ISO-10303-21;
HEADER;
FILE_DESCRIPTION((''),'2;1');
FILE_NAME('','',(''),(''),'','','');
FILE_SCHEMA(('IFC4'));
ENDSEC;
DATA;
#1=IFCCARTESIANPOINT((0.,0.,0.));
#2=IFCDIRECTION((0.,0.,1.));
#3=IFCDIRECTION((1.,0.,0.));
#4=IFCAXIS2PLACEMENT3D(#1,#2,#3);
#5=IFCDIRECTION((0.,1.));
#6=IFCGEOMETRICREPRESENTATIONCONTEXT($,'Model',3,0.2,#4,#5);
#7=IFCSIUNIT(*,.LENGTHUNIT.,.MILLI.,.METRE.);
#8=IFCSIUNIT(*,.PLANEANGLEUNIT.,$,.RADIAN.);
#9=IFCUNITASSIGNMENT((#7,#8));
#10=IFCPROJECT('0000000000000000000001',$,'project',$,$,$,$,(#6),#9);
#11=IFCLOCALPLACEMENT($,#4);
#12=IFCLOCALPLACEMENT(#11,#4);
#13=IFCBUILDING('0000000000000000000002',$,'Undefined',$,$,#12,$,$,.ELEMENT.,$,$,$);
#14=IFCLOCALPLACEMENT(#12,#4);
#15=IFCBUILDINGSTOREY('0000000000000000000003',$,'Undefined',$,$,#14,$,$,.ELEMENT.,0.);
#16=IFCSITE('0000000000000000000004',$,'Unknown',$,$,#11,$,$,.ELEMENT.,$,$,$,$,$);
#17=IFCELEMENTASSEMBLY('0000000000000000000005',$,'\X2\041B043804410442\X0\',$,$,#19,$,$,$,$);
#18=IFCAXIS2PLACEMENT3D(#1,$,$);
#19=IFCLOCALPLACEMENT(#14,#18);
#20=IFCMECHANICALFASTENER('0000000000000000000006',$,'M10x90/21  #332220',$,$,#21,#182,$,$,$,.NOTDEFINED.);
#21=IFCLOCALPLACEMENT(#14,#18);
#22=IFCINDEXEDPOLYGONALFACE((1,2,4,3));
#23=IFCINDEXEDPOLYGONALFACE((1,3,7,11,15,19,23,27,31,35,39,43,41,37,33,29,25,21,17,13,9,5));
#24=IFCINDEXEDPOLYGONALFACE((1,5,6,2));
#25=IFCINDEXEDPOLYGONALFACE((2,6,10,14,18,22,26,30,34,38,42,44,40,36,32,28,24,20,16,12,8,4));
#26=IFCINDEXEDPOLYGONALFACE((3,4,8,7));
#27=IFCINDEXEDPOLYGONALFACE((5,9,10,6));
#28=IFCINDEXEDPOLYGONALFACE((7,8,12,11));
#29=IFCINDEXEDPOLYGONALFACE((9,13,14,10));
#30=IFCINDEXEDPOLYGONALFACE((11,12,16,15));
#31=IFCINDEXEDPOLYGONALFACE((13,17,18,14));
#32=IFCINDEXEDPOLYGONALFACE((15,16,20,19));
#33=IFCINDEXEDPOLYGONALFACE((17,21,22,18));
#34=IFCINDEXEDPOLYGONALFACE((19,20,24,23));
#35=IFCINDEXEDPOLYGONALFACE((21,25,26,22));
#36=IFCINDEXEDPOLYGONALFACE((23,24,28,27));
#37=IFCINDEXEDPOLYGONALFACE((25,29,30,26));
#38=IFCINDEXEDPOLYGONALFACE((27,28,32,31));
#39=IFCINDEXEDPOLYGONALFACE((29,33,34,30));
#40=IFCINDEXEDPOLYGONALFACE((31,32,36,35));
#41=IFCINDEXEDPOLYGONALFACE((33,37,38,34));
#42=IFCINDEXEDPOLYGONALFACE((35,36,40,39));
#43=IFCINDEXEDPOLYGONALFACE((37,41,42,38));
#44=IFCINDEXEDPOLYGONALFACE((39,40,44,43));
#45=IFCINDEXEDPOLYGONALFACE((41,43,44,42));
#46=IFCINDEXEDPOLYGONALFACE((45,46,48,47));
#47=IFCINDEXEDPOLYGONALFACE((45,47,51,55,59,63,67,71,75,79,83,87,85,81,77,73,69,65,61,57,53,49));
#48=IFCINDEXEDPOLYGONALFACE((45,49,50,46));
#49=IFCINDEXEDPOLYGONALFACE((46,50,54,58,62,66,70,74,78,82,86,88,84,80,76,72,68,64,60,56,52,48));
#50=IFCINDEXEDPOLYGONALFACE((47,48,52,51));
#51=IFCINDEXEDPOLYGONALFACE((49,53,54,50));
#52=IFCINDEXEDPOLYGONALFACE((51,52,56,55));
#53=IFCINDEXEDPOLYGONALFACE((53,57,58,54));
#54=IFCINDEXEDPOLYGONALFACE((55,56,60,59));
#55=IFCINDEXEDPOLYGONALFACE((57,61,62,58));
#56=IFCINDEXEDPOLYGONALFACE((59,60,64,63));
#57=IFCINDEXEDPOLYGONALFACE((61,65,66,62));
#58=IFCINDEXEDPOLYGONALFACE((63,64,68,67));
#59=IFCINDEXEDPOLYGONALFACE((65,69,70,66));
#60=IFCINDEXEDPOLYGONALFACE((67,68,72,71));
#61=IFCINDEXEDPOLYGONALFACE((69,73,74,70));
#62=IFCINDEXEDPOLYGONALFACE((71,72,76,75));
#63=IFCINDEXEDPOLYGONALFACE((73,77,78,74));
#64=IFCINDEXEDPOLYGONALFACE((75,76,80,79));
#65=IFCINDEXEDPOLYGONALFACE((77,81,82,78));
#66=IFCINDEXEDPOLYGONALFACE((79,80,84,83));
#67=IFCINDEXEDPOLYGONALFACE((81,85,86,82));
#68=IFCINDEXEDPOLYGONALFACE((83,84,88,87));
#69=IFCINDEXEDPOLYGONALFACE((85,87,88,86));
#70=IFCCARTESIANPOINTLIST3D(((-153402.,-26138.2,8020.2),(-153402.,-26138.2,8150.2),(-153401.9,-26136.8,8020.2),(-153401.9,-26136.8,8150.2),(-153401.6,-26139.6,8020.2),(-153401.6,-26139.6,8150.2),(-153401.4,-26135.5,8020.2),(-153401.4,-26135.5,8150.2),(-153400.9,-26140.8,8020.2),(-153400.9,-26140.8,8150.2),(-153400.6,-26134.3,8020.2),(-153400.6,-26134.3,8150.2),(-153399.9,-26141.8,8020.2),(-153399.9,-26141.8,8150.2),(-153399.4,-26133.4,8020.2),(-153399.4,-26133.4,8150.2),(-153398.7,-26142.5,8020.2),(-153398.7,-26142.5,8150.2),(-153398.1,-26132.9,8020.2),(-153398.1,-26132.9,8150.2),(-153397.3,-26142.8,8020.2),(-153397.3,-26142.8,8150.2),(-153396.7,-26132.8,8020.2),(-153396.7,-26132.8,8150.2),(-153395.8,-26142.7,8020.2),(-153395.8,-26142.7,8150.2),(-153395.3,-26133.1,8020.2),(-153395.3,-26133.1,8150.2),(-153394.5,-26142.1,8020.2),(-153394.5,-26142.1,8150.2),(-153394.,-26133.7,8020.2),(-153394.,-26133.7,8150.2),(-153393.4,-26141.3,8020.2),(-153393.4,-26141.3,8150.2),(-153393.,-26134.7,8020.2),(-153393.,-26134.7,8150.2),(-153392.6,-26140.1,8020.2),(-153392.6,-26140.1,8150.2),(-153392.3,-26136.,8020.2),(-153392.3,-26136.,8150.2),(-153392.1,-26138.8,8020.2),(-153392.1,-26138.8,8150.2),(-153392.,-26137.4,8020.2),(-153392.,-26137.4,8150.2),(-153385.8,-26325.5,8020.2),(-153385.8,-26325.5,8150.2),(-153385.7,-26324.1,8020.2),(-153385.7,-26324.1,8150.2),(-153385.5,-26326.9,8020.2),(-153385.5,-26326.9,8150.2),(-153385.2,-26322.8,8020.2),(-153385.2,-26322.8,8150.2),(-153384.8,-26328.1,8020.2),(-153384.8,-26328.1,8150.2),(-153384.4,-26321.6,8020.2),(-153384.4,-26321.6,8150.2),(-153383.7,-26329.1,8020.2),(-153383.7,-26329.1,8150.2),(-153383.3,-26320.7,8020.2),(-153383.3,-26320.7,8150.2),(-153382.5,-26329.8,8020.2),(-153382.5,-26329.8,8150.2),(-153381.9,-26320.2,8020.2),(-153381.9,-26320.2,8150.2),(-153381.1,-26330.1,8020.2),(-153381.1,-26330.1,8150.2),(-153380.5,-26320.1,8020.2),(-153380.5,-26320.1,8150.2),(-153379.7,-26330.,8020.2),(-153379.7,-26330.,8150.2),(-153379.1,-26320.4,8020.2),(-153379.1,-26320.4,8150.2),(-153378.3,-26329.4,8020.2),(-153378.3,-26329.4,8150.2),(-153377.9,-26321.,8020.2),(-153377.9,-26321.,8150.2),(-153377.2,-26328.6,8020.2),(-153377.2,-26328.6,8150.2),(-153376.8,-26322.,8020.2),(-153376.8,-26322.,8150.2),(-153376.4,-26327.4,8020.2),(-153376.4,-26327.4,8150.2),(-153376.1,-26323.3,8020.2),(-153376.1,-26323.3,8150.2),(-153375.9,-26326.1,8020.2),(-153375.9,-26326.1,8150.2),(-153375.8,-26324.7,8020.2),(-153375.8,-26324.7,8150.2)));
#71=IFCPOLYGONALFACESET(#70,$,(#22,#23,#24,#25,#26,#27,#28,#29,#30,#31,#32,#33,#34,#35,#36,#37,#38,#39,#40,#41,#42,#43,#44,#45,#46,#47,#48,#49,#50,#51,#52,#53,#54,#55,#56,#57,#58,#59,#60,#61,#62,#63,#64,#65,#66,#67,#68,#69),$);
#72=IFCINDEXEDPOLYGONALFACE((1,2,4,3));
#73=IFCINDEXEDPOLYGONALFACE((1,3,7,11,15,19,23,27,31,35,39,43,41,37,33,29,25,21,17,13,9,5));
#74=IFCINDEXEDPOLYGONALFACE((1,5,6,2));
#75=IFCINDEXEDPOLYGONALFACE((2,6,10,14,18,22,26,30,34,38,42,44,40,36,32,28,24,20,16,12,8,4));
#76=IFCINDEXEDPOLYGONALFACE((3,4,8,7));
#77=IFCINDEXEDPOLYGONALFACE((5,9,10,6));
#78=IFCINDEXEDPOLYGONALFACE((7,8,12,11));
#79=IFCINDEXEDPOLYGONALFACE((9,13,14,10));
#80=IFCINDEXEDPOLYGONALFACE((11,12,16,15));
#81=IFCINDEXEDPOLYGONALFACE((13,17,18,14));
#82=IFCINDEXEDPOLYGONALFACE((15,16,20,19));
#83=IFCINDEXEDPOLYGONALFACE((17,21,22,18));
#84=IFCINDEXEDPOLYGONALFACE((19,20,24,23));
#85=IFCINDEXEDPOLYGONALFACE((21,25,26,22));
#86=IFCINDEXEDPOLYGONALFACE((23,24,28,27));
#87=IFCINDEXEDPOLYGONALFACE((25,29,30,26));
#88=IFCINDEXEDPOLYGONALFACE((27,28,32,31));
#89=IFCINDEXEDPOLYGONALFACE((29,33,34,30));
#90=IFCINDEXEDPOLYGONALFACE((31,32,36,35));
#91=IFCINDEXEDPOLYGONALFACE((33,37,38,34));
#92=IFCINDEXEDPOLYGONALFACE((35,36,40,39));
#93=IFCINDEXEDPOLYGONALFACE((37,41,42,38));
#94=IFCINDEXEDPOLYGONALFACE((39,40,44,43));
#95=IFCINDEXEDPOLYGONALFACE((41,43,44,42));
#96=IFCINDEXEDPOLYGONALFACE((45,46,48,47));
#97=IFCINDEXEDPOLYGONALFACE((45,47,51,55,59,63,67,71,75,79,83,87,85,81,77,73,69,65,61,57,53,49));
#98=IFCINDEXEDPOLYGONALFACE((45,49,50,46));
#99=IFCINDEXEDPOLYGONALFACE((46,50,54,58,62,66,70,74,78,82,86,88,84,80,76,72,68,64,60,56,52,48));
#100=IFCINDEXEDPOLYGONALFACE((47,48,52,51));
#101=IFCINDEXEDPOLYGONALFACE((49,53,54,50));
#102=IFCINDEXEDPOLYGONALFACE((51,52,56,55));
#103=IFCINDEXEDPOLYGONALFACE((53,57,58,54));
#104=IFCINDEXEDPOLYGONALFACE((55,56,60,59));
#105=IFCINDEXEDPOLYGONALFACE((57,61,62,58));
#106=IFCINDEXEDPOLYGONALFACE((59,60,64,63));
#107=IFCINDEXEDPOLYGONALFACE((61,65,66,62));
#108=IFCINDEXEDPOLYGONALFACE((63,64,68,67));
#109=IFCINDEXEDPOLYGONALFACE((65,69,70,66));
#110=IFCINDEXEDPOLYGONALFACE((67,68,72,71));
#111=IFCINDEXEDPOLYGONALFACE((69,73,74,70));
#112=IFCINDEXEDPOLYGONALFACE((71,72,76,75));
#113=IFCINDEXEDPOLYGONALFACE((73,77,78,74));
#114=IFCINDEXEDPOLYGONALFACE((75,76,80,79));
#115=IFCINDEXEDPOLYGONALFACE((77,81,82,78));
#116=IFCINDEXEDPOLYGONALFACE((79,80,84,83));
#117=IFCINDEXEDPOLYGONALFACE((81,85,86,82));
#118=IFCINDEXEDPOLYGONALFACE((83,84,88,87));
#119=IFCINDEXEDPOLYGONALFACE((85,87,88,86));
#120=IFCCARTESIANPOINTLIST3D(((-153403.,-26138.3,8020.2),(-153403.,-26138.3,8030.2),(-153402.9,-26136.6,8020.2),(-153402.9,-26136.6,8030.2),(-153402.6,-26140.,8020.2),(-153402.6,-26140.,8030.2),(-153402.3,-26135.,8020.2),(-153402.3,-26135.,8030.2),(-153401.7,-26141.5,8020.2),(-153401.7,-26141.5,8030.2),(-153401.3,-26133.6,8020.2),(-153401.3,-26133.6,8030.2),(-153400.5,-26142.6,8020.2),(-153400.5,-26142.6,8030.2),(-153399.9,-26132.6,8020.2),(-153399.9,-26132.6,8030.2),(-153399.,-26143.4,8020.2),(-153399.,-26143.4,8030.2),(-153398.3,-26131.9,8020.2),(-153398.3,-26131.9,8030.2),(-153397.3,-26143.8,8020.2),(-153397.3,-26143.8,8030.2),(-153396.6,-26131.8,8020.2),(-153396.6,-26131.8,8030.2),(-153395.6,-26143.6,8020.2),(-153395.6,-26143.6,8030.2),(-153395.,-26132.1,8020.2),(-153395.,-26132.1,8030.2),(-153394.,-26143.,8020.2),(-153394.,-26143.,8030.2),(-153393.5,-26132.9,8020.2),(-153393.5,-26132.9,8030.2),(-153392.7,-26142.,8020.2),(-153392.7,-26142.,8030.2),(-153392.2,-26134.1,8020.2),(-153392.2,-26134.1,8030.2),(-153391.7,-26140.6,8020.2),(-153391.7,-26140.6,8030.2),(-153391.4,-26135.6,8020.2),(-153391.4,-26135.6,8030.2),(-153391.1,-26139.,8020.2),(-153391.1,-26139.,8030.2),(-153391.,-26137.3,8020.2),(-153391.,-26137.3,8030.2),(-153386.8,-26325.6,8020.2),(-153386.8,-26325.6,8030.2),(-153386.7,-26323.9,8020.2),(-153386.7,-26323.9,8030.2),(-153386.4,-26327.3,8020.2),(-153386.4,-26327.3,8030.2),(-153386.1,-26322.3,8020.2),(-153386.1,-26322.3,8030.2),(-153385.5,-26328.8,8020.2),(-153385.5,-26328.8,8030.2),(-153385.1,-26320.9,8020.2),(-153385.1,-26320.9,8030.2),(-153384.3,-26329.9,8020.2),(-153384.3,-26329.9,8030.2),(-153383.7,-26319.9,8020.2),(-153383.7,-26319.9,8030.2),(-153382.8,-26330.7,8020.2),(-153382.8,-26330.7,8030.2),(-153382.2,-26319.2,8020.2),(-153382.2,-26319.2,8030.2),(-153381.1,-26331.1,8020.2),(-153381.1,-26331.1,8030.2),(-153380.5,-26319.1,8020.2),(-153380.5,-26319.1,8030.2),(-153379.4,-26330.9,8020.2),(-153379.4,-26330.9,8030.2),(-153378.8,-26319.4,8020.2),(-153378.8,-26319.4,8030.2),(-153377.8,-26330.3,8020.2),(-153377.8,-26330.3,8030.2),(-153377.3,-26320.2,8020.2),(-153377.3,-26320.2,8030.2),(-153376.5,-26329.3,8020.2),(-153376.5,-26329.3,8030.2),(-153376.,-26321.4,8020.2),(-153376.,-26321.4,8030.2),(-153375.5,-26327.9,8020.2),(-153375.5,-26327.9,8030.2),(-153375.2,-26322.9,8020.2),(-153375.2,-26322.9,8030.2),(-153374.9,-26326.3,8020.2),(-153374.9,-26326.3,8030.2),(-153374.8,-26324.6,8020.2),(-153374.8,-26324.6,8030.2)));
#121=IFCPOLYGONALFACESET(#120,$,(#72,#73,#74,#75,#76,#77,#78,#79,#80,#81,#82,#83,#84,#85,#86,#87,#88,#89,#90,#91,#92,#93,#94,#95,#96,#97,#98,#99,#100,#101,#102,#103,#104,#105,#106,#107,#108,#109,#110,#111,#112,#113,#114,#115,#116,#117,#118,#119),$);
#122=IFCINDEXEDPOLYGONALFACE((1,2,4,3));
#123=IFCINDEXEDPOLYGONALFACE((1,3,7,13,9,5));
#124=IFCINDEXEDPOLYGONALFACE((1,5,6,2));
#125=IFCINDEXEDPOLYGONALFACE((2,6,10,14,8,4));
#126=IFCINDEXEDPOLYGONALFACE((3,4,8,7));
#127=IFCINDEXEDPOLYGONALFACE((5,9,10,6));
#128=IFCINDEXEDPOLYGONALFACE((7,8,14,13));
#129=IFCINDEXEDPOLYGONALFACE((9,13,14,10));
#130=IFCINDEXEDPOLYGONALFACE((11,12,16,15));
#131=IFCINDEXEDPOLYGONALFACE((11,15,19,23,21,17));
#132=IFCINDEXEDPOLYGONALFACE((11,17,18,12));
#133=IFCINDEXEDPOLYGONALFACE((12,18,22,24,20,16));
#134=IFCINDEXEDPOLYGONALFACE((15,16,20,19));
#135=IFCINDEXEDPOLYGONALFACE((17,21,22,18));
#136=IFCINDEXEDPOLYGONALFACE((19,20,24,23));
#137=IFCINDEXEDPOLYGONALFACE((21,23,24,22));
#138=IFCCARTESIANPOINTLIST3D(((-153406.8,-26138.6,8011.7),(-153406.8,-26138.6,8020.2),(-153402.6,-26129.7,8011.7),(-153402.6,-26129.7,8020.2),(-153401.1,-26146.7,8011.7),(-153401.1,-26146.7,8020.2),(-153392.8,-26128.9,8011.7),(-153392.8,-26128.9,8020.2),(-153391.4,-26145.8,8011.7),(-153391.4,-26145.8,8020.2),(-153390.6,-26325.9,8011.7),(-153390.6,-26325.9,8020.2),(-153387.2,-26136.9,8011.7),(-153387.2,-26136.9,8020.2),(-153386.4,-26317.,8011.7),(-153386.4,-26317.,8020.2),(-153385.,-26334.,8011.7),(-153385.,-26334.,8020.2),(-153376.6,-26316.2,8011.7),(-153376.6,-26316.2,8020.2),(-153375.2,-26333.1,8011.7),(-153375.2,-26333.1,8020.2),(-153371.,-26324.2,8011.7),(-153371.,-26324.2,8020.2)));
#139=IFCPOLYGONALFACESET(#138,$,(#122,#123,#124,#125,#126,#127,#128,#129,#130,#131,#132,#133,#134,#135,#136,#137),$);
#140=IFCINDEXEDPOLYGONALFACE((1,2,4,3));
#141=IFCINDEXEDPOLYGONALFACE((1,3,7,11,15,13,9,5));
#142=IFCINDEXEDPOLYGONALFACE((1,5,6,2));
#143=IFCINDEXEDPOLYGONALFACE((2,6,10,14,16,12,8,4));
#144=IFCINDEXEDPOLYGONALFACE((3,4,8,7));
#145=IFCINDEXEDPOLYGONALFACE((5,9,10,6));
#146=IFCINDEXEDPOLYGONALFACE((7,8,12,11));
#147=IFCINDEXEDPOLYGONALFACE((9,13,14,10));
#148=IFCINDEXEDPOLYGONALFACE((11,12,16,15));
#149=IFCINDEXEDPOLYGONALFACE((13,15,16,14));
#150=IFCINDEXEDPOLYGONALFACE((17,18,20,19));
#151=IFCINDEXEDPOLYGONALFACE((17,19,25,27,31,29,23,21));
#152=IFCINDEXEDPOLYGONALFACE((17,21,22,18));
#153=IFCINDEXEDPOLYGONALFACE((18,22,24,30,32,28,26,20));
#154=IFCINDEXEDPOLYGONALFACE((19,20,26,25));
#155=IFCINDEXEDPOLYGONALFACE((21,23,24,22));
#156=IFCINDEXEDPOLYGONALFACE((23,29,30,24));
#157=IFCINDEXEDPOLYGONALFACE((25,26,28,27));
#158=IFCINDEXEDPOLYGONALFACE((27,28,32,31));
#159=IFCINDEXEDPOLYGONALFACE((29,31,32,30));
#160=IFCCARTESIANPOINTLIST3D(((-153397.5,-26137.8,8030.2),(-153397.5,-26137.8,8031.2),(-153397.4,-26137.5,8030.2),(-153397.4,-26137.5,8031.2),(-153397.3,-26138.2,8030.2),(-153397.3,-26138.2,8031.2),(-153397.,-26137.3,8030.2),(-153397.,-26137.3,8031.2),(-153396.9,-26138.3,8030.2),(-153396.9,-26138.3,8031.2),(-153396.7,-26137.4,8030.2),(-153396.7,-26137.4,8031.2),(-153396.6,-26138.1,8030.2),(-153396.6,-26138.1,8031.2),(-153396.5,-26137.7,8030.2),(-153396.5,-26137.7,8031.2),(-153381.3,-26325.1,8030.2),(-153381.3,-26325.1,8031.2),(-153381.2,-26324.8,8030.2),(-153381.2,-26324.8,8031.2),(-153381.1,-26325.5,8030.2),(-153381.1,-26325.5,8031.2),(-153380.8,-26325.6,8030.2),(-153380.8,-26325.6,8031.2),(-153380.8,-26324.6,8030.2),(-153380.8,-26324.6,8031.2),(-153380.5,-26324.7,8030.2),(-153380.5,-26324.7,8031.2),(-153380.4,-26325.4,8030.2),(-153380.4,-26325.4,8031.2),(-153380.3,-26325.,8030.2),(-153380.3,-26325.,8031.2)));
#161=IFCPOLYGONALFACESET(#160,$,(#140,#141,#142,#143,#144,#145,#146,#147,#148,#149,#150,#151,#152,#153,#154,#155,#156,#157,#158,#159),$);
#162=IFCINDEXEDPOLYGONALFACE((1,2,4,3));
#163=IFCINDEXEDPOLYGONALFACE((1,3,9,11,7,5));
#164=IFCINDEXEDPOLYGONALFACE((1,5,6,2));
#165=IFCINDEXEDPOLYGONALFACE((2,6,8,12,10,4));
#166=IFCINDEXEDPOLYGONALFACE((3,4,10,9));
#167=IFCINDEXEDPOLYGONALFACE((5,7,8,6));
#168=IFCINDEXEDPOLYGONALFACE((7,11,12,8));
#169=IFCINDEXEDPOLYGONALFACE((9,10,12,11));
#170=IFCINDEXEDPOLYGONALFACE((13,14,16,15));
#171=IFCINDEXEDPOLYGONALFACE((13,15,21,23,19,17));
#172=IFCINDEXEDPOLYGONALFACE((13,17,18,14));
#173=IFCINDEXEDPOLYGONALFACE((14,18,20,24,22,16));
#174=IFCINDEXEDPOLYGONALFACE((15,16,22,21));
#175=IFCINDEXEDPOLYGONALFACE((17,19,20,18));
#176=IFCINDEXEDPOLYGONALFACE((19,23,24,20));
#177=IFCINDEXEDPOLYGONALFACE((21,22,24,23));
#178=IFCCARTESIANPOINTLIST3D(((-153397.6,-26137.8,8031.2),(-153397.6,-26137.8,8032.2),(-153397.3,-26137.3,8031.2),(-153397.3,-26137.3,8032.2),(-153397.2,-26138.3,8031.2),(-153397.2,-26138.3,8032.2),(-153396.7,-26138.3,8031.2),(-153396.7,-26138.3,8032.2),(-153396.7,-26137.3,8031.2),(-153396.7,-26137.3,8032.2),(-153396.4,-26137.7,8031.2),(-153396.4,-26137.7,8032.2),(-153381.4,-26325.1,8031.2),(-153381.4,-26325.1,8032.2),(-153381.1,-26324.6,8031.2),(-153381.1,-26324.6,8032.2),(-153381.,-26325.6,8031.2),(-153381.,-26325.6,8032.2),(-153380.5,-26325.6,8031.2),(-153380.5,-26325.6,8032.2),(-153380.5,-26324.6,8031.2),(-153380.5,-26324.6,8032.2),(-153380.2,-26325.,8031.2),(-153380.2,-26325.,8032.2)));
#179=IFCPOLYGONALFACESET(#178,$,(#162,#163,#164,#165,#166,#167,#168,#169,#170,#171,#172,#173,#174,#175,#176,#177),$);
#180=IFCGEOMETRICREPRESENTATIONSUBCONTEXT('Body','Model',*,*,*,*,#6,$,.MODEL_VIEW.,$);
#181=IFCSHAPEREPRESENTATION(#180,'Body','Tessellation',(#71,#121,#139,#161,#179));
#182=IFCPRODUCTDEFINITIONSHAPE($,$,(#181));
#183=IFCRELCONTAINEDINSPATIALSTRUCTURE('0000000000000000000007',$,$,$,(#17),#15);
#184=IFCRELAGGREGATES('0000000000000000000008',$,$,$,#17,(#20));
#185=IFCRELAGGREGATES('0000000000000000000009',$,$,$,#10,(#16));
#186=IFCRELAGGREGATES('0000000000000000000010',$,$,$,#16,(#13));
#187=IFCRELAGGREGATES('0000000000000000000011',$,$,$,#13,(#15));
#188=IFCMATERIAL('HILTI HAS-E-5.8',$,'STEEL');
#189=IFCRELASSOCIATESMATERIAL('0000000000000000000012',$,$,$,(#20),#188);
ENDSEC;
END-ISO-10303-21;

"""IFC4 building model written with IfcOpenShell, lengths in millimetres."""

from ifc_helpers import new_model, si_unit, direction, frame, origin_with_axes, place, context, subcontext, project, spatial, line, arc, indexed_curve, outline, extrude, source, transform, mapped, material, element, aggregate, save


model = new_model("IFC4")

# Units and contexts
model_context = context("Model", 3, precision=0.2, world=origin_with_axes(), true_north=direction((0.0, 1.0)))
body_context = subcontext(model_context, "Body", "Model", "MODEL_VIEW")
ifc_project = project(units=[si_unit("LENGTHUNIT", "METRE", prefix="MILLI"), si_unit("PLANEANGLEUNIT", "RADIAN")], contexts=[model_context])

# Site, building, storey
site_placement = place(None, origin_with_axes())
site = spatial("IfcSite", under=ifc_project, at=site_placement, Name="Unknown", CompositionType="ELEMENT")
building_placement = place(site_placement, origin_with_axes())
building = spatial("IfcBuilding", under=site, at=building_placement, Name="Undefined", CompositionType="ELEMENT")
storey_placement = place(building_placement, origin_with_axes())
storey = spatial("IfcBuildingStorey", under=building, at=storey_placement, Name="Undefined", CompositionType="ELEMENT", Elevation=0.0)

# Element assembly
assembly_1_placement = place(storey_placement, frame((-153308.2, -26351.9, 8025.2), z_axis=(0.0, 0.0, 1.0), x_axis=(-0.086114, 0.996285, 0.0)))
assembly_1 = element("IfcElementAssembly", 1, at=assembly_1_placement, inside=storey, Name="Лист")

# Mechanical fastener
ifc_material_1 = material(Name="HILTI HAS-E-5.8", Category="STEEL")
shared_shape_1 = source(origin_with_axes(), body_context, "Body", "SweptSolid", [
    extrude(outline(indexed_curve([(5.0, 0.0), (0.0, 5.0), (-5.0, 0.0), (0.0, -5.0)], segments=[arc(1, 2, 3), arc(3, 4, 1)])), frame((0.0, 0.0, 0.0), z_axis=(0.0, 0.0, -1.0), x_axis=(0.0, 1.0, 0.0)), (0.0, 0.0, 1.0), 130.0),
    extrude(outline(indexed_curve([(6.0, 0.0), (0.0, 6.0), (-6.0, 0.0), (0.0, -6.0)], segments=[arc(1, 2, 3), arc(3, 4, 1)])), frame((0.0, 0.0, 0.0), z_axis=(0.0, 0.0, -1.0), x_axis=(0.0, 1.0, 0.0)), (0.0, 0.0, 1.0), 10.0),
    extrude(outline(indexed_curve([(9.8, 0.0), (4.9, 8.5), (-4.9, 8.5), (-9.8, 0.0), (-4.9, -8.5), (4.9, -8.5)], segments=[line(1, 2, 3, 4, 5, 6, 1)])), frame((0.0, 0.0, 8.5), z_axis=(0.0, 0.0, -1.0), x_axis=(0.0, 1.0, 0.0)), (0.0, 0.0, 1.0), 8.5),
    extrude(outline(indexed_curve([(0.5, 0.0), (0.0, 0.5), (-0.5, 0.0), (0.0, -0.5)], segments=[arc(1, 2, 3), arc(3, 4, 1)])), frame((0.0, 0.0, -10.0), z_axis=(0.0, 0.0, -1.0), x_axis=(0.0, 1.0, 0.0)), (0.0, 0.0, 1.0), 1.0),
    extrude(outline(indexed_curve([(0.6, 0.0), (0.3, 0.5), (-0.3, 0.5), (-0.6, 0.0), (-0.3, -0.5), (0.3, -0.5)], segments=[line(1, 2, 3, 4, 5, 6, 1)])), frame((0.0, 0.0, -11.0), z_axis=(0.0, 0.0, -1.0), x_axis=(0.0, 1.0, 0.0)), (0.0, 0.0, 1.0), 1.0),
])
mechanical_fastener_1_placement = place(assembly_1_placement, frame((221.0, 70.0, -5.0), z_axis=(0.0, 0.0, -1.0), x_axis=(-1.0, 0.0, 0.0)))
mechanical_fastener_1 = element("IfcMechanicalFastener", 2, at=mechanical_fastener_1_placement, material=ifc_material_1, Name="M10x90/21  #332220", PredefinedType="NOTDEFINED", context=body_context, shape_type="MappedRepresentation", body=[
    mapped(shared_shape_1, transform((0.0, 0.0, 0.0))),
    mapped(shared_shape_1, transform((188.0, 0.0, 0.0))),
])
aggregate(assembly_1, [mechanical_fastener_1])

save(model, "model.ifc")
